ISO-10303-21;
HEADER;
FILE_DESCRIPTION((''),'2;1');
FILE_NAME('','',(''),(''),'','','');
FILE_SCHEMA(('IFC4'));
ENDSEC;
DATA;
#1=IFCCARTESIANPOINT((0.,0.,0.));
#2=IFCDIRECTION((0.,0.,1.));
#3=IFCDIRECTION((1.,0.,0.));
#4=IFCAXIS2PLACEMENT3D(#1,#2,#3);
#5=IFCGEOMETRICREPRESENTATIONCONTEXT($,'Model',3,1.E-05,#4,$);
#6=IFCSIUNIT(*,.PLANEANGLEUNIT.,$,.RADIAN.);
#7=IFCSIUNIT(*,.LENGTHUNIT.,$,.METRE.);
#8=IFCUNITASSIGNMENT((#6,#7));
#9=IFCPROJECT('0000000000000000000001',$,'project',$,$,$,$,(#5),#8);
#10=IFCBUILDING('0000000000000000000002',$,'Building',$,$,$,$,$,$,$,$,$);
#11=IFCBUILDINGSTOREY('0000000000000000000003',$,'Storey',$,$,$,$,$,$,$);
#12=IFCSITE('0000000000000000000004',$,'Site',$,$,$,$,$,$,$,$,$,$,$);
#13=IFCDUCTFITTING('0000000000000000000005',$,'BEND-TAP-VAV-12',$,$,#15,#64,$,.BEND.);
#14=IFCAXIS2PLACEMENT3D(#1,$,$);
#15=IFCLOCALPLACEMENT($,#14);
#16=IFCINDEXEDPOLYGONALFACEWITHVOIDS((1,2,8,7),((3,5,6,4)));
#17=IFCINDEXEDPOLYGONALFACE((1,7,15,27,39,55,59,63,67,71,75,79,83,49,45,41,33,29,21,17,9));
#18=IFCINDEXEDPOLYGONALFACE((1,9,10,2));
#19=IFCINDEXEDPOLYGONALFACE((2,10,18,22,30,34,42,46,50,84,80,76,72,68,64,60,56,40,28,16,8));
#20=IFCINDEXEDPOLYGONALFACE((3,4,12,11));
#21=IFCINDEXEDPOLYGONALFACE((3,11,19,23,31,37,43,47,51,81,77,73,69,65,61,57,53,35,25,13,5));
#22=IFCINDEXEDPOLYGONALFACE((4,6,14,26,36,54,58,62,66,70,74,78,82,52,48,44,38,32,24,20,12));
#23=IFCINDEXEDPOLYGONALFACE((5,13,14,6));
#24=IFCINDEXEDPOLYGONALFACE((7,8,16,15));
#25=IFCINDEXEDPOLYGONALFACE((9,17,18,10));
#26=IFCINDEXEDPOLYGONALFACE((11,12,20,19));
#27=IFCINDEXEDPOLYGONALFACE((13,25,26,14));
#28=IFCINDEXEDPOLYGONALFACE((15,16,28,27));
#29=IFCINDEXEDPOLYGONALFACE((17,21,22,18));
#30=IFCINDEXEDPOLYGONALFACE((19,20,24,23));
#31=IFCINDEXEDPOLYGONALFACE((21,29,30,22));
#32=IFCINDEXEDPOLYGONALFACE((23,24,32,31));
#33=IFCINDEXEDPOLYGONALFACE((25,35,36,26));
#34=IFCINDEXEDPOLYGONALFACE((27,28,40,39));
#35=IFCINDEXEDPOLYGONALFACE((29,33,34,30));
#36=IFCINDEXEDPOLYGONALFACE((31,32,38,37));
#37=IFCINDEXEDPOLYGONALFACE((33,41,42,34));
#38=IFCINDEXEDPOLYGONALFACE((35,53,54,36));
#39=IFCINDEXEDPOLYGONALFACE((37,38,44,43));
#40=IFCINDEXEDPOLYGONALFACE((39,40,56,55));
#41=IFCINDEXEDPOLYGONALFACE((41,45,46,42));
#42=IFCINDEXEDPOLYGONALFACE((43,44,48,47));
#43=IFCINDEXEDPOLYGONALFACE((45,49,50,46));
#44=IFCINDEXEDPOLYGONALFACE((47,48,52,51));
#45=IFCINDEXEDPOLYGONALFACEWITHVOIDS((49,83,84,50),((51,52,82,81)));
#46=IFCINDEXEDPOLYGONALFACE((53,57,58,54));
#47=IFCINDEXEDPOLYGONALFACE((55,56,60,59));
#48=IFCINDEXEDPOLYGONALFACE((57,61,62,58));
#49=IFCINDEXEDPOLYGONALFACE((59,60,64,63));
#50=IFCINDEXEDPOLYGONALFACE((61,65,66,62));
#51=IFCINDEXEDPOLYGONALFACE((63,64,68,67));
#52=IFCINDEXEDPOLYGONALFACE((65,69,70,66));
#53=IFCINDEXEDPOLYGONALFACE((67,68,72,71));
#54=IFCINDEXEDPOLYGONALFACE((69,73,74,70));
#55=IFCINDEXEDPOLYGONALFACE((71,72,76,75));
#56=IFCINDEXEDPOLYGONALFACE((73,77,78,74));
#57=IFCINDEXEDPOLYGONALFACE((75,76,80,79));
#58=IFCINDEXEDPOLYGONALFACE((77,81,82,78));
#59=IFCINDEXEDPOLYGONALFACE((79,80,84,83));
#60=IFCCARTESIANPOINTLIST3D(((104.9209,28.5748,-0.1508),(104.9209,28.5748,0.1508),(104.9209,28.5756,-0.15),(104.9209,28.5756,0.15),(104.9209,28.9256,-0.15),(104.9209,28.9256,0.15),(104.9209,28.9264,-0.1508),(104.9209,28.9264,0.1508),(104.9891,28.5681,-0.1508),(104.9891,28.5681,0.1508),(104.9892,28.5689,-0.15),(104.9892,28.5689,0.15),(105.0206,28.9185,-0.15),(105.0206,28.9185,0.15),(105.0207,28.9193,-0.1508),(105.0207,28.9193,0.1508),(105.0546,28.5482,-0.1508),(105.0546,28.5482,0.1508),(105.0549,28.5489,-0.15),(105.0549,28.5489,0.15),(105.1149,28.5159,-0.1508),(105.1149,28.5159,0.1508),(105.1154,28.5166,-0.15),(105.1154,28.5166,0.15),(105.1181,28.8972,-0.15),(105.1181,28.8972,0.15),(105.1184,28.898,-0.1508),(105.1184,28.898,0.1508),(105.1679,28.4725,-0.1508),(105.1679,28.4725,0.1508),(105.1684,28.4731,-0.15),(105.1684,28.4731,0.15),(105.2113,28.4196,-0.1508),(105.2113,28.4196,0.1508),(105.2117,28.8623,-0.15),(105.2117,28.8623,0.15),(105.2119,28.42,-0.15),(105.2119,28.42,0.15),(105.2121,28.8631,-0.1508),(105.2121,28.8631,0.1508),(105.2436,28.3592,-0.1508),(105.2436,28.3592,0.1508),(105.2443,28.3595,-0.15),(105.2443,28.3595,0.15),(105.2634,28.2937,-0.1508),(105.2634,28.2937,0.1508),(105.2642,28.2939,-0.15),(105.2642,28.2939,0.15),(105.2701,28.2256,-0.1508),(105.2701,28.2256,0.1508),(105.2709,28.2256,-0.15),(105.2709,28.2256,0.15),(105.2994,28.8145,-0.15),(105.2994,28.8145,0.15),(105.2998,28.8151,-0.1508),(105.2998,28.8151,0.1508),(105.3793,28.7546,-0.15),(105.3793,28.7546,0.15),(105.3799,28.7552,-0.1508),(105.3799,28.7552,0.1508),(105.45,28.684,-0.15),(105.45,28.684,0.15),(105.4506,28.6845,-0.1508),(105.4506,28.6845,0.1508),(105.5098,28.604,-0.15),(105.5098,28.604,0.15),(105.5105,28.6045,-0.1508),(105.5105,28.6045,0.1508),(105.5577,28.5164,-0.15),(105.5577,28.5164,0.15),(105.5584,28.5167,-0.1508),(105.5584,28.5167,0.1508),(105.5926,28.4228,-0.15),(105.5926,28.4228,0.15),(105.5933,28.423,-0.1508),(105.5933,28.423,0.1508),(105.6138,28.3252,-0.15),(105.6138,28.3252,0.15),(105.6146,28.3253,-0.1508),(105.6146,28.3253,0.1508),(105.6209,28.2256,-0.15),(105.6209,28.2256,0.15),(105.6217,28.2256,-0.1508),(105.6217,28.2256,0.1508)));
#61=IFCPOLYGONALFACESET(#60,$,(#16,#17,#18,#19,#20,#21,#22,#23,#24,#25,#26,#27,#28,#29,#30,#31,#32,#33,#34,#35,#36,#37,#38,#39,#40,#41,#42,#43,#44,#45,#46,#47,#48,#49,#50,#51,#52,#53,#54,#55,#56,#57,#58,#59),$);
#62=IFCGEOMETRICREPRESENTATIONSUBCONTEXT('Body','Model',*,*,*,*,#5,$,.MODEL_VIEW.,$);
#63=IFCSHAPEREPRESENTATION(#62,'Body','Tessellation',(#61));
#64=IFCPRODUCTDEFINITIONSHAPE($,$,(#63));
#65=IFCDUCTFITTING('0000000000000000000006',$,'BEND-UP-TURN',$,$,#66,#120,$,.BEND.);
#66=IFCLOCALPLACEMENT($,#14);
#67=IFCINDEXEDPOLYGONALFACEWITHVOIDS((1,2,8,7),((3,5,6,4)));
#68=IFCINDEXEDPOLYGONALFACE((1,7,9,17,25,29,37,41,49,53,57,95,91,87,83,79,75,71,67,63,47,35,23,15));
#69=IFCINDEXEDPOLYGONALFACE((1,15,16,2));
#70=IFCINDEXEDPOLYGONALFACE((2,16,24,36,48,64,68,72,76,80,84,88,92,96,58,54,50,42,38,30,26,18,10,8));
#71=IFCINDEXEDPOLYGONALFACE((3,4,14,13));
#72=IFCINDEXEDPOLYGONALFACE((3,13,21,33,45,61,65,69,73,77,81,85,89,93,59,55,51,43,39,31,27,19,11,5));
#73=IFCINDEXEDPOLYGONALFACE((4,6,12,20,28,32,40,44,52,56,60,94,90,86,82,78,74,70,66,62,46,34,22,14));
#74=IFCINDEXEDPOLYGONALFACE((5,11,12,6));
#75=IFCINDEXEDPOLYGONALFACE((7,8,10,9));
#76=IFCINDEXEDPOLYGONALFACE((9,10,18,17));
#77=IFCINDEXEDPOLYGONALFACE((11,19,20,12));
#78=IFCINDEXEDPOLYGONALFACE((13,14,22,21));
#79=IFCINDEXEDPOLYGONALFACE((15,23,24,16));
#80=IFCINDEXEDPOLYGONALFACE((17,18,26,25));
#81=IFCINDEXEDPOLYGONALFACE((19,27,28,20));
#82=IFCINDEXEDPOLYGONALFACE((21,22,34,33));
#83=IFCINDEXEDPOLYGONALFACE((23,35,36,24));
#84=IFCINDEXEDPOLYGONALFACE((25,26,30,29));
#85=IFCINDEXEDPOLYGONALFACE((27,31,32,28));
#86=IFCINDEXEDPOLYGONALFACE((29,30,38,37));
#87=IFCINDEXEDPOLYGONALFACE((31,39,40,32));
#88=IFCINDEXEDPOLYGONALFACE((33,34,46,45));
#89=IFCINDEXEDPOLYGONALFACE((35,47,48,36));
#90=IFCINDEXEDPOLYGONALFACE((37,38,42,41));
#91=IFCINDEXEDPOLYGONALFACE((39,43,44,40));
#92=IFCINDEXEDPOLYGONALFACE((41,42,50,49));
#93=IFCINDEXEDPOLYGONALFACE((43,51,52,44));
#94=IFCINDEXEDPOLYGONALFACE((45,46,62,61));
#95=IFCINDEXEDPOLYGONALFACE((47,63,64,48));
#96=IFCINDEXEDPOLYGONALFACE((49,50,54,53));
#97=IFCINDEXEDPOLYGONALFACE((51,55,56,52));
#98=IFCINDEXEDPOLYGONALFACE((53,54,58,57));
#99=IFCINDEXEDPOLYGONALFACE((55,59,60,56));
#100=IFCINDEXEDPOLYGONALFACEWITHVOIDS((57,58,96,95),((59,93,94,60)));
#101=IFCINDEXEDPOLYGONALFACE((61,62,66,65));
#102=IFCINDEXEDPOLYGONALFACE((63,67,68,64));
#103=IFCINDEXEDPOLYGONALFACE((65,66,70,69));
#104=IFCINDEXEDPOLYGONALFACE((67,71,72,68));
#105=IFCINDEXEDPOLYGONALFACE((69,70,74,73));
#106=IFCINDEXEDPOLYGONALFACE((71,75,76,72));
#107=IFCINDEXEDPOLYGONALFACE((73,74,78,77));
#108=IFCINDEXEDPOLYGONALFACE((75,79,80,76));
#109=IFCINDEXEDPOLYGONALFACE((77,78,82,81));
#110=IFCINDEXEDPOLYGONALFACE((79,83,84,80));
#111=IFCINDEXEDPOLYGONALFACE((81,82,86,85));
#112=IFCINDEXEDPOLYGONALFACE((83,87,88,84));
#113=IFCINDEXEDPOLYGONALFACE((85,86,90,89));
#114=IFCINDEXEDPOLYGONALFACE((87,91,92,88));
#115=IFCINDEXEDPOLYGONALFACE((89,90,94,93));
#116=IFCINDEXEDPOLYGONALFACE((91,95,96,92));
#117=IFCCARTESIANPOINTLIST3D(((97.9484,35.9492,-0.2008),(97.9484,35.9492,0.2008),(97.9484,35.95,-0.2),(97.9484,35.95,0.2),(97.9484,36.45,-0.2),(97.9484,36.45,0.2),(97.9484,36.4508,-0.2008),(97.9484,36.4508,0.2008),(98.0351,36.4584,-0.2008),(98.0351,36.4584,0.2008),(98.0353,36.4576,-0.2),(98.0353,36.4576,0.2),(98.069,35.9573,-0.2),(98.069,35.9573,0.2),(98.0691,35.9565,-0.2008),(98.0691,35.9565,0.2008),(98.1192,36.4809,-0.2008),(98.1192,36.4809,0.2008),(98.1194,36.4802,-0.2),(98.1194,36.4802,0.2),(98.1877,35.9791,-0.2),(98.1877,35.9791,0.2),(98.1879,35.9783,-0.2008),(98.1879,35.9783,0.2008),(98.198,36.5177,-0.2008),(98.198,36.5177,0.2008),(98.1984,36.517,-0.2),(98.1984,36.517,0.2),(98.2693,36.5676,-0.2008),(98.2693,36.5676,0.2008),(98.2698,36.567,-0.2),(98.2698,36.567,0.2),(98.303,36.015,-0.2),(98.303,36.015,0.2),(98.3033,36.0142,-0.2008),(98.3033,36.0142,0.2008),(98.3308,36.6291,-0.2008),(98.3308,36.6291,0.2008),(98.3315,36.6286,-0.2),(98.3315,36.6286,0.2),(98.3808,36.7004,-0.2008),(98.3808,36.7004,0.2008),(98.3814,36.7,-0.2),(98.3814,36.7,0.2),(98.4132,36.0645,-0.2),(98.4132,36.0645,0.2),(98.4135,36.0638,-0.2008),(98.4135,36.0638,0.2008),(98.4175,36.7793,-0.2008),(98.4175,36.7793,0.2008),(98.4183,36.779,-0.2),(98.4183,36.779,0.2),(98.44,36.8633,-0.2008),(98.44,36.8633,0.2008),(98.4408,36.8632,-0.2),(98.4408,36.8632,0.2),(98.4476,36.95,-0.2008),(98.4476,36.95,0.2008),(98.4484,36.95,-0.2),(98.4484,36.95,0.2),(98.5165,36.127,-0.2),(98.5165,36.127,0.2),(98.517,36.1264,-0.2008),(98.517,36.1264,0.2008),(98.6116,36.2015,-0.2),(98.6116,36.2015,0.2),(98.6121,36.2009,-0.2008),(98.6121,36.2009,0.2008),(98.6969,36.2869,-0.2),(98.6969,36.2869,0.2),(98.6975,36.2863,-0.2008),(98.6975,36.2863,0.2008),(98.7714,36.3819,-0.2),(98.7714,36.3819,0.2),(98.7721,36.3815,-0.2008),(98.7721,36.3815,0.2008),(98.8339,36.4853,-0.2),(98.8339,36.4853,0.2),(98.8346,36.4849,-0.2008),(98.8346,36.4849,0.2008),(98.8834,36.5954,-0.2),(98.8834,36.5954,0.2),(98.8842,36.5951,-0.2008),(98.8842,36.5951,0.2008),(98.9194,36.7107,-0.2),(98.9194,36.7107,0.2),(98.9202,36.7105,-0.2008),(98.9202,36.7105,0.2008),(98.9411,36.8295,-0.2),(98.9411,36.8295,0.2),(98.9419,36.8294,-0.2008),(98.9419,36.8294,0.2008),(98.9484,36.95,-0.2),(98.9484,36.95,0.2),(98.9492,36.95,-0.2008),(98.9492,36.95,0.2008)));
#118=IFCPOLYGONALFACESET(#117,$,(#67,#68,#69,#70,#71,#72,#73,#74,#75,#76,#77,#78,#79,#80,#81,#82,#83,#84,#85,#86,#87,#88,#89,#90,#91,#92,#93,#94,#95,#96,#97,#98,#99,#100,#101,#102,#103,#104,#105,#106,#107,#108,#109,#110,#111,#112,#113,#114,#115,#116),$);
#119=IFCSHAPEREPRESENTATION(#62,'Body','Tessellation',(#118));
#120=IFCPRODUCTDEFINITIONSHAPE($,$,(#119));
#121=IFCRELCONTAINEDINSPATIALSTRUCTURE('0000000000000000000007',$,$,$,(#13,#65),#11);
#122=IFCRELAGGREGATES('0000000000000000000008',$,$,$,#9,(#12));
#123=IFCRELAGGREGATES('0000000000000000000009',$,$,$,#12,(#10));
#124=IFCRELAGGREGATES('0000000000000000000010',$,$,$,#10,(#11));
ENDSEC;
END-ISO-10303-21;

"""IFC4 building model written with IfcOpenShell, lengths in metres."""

from ifc_helpers import new_model, entity, si_unit, frame, origin_with_axes, place, context, subcontext, project, spatial, element, save


model = new_model("IFC4")

# Units and contexts
model_context = context("Model", 3, precision=1e-05, world=origin_with_axes())
body_context = subcontext(model_context, "Body", "Model", "MODEL_VIEW")
ifc_project = project(units=[si_unit("PLANEANGLEUNIT", "RADIAN"), si_unit("LENGTHUNIT", "METRE")], contexts=[model_context])

# Site, building, storey
site = spatial("IfcSite", under=ifc_project, Name="Site")
building = spatial("IfcBuilding", under=site, Name="Building")
storey = spatial("IfcBuildingStorey", under=building, Name="Storey")

# Duct fittings
duct_fitting_1_placement = place(None, frame((104.9209, 28.2256, 0.0), z_axis=(0.0, 0.0, -1.0), x_axis=(0.0, 1.0, 0.0)))
cartesian_point_1 = entity("IfcCartesianPoint", [0.0, 0.0, 0.0])
element("IfcDuctFitting", 1, at=duct_fitting_1_placement, inside=storey, Name="BEND-TAP-VAV-12", PredefinedType="BEND", context=body_context, shape_type="SweptSolid", body=[
    entity("IfcRevolvedAreaSolid", entity("IfcRectangleHollowProfileDef", "AREA", None, entity("IfcAxis2Placement2D", entity("IfcCartesianPoint", [0.525, 0.0])), 0.3516, 0.3016, 0.0008), entity("IfcAxis2Placement3D", cartesian_point_1, entity("IfcDirection", [0.0, -1.0, 0.0]), entity("IfcDirection", [1.0, 0.0, 0.0])), entity("IfcAxis1Placement", cartesian_point_1, entity("IfcDirection", [0.0, 1.0, 0.0])), 1.570796),
])
duct_fitting_2_placement = place(None, frame((97.9484, 36.95, 0.0), z_axis=(0.0, 0.0, 1.0), x_axis=(0.0, -1.0, 0.0)))
cartesian_point_2 = entity("IfcCartesianPoint", [0.0, 0.0, 0.0])
element("IfcDuctFitting", 2, at=duct_fitting_2_placement, inside=storey, Name="BEND-UP-TURN", PredefinedType="BEND", context=body_context, shape_type="SweptSolid", body=[
    entity("IfcRevolvedAreaSolid", entity("IfcRectangleHollowProfileDef", "AREA", None, entity("IfcAxis2Placement2D", entity("IfcCartesianPoint", [0.75, 0.0])), 0.5016, 0.4016, 0.0008), entity("IfcAxis2Placement3D", cartesian_point_2, entity("IfcDirection", [0.0, -1.0, 0.0]), entity("IfcDirection", [1.0, 0.0, 0.0])), entity("IfcAxis1Placement", cartesian_point_2, entity("IfcDirection", [0.0, 1.0, 0.0])), 1.570796),
])

save(model, "model.ifc")
